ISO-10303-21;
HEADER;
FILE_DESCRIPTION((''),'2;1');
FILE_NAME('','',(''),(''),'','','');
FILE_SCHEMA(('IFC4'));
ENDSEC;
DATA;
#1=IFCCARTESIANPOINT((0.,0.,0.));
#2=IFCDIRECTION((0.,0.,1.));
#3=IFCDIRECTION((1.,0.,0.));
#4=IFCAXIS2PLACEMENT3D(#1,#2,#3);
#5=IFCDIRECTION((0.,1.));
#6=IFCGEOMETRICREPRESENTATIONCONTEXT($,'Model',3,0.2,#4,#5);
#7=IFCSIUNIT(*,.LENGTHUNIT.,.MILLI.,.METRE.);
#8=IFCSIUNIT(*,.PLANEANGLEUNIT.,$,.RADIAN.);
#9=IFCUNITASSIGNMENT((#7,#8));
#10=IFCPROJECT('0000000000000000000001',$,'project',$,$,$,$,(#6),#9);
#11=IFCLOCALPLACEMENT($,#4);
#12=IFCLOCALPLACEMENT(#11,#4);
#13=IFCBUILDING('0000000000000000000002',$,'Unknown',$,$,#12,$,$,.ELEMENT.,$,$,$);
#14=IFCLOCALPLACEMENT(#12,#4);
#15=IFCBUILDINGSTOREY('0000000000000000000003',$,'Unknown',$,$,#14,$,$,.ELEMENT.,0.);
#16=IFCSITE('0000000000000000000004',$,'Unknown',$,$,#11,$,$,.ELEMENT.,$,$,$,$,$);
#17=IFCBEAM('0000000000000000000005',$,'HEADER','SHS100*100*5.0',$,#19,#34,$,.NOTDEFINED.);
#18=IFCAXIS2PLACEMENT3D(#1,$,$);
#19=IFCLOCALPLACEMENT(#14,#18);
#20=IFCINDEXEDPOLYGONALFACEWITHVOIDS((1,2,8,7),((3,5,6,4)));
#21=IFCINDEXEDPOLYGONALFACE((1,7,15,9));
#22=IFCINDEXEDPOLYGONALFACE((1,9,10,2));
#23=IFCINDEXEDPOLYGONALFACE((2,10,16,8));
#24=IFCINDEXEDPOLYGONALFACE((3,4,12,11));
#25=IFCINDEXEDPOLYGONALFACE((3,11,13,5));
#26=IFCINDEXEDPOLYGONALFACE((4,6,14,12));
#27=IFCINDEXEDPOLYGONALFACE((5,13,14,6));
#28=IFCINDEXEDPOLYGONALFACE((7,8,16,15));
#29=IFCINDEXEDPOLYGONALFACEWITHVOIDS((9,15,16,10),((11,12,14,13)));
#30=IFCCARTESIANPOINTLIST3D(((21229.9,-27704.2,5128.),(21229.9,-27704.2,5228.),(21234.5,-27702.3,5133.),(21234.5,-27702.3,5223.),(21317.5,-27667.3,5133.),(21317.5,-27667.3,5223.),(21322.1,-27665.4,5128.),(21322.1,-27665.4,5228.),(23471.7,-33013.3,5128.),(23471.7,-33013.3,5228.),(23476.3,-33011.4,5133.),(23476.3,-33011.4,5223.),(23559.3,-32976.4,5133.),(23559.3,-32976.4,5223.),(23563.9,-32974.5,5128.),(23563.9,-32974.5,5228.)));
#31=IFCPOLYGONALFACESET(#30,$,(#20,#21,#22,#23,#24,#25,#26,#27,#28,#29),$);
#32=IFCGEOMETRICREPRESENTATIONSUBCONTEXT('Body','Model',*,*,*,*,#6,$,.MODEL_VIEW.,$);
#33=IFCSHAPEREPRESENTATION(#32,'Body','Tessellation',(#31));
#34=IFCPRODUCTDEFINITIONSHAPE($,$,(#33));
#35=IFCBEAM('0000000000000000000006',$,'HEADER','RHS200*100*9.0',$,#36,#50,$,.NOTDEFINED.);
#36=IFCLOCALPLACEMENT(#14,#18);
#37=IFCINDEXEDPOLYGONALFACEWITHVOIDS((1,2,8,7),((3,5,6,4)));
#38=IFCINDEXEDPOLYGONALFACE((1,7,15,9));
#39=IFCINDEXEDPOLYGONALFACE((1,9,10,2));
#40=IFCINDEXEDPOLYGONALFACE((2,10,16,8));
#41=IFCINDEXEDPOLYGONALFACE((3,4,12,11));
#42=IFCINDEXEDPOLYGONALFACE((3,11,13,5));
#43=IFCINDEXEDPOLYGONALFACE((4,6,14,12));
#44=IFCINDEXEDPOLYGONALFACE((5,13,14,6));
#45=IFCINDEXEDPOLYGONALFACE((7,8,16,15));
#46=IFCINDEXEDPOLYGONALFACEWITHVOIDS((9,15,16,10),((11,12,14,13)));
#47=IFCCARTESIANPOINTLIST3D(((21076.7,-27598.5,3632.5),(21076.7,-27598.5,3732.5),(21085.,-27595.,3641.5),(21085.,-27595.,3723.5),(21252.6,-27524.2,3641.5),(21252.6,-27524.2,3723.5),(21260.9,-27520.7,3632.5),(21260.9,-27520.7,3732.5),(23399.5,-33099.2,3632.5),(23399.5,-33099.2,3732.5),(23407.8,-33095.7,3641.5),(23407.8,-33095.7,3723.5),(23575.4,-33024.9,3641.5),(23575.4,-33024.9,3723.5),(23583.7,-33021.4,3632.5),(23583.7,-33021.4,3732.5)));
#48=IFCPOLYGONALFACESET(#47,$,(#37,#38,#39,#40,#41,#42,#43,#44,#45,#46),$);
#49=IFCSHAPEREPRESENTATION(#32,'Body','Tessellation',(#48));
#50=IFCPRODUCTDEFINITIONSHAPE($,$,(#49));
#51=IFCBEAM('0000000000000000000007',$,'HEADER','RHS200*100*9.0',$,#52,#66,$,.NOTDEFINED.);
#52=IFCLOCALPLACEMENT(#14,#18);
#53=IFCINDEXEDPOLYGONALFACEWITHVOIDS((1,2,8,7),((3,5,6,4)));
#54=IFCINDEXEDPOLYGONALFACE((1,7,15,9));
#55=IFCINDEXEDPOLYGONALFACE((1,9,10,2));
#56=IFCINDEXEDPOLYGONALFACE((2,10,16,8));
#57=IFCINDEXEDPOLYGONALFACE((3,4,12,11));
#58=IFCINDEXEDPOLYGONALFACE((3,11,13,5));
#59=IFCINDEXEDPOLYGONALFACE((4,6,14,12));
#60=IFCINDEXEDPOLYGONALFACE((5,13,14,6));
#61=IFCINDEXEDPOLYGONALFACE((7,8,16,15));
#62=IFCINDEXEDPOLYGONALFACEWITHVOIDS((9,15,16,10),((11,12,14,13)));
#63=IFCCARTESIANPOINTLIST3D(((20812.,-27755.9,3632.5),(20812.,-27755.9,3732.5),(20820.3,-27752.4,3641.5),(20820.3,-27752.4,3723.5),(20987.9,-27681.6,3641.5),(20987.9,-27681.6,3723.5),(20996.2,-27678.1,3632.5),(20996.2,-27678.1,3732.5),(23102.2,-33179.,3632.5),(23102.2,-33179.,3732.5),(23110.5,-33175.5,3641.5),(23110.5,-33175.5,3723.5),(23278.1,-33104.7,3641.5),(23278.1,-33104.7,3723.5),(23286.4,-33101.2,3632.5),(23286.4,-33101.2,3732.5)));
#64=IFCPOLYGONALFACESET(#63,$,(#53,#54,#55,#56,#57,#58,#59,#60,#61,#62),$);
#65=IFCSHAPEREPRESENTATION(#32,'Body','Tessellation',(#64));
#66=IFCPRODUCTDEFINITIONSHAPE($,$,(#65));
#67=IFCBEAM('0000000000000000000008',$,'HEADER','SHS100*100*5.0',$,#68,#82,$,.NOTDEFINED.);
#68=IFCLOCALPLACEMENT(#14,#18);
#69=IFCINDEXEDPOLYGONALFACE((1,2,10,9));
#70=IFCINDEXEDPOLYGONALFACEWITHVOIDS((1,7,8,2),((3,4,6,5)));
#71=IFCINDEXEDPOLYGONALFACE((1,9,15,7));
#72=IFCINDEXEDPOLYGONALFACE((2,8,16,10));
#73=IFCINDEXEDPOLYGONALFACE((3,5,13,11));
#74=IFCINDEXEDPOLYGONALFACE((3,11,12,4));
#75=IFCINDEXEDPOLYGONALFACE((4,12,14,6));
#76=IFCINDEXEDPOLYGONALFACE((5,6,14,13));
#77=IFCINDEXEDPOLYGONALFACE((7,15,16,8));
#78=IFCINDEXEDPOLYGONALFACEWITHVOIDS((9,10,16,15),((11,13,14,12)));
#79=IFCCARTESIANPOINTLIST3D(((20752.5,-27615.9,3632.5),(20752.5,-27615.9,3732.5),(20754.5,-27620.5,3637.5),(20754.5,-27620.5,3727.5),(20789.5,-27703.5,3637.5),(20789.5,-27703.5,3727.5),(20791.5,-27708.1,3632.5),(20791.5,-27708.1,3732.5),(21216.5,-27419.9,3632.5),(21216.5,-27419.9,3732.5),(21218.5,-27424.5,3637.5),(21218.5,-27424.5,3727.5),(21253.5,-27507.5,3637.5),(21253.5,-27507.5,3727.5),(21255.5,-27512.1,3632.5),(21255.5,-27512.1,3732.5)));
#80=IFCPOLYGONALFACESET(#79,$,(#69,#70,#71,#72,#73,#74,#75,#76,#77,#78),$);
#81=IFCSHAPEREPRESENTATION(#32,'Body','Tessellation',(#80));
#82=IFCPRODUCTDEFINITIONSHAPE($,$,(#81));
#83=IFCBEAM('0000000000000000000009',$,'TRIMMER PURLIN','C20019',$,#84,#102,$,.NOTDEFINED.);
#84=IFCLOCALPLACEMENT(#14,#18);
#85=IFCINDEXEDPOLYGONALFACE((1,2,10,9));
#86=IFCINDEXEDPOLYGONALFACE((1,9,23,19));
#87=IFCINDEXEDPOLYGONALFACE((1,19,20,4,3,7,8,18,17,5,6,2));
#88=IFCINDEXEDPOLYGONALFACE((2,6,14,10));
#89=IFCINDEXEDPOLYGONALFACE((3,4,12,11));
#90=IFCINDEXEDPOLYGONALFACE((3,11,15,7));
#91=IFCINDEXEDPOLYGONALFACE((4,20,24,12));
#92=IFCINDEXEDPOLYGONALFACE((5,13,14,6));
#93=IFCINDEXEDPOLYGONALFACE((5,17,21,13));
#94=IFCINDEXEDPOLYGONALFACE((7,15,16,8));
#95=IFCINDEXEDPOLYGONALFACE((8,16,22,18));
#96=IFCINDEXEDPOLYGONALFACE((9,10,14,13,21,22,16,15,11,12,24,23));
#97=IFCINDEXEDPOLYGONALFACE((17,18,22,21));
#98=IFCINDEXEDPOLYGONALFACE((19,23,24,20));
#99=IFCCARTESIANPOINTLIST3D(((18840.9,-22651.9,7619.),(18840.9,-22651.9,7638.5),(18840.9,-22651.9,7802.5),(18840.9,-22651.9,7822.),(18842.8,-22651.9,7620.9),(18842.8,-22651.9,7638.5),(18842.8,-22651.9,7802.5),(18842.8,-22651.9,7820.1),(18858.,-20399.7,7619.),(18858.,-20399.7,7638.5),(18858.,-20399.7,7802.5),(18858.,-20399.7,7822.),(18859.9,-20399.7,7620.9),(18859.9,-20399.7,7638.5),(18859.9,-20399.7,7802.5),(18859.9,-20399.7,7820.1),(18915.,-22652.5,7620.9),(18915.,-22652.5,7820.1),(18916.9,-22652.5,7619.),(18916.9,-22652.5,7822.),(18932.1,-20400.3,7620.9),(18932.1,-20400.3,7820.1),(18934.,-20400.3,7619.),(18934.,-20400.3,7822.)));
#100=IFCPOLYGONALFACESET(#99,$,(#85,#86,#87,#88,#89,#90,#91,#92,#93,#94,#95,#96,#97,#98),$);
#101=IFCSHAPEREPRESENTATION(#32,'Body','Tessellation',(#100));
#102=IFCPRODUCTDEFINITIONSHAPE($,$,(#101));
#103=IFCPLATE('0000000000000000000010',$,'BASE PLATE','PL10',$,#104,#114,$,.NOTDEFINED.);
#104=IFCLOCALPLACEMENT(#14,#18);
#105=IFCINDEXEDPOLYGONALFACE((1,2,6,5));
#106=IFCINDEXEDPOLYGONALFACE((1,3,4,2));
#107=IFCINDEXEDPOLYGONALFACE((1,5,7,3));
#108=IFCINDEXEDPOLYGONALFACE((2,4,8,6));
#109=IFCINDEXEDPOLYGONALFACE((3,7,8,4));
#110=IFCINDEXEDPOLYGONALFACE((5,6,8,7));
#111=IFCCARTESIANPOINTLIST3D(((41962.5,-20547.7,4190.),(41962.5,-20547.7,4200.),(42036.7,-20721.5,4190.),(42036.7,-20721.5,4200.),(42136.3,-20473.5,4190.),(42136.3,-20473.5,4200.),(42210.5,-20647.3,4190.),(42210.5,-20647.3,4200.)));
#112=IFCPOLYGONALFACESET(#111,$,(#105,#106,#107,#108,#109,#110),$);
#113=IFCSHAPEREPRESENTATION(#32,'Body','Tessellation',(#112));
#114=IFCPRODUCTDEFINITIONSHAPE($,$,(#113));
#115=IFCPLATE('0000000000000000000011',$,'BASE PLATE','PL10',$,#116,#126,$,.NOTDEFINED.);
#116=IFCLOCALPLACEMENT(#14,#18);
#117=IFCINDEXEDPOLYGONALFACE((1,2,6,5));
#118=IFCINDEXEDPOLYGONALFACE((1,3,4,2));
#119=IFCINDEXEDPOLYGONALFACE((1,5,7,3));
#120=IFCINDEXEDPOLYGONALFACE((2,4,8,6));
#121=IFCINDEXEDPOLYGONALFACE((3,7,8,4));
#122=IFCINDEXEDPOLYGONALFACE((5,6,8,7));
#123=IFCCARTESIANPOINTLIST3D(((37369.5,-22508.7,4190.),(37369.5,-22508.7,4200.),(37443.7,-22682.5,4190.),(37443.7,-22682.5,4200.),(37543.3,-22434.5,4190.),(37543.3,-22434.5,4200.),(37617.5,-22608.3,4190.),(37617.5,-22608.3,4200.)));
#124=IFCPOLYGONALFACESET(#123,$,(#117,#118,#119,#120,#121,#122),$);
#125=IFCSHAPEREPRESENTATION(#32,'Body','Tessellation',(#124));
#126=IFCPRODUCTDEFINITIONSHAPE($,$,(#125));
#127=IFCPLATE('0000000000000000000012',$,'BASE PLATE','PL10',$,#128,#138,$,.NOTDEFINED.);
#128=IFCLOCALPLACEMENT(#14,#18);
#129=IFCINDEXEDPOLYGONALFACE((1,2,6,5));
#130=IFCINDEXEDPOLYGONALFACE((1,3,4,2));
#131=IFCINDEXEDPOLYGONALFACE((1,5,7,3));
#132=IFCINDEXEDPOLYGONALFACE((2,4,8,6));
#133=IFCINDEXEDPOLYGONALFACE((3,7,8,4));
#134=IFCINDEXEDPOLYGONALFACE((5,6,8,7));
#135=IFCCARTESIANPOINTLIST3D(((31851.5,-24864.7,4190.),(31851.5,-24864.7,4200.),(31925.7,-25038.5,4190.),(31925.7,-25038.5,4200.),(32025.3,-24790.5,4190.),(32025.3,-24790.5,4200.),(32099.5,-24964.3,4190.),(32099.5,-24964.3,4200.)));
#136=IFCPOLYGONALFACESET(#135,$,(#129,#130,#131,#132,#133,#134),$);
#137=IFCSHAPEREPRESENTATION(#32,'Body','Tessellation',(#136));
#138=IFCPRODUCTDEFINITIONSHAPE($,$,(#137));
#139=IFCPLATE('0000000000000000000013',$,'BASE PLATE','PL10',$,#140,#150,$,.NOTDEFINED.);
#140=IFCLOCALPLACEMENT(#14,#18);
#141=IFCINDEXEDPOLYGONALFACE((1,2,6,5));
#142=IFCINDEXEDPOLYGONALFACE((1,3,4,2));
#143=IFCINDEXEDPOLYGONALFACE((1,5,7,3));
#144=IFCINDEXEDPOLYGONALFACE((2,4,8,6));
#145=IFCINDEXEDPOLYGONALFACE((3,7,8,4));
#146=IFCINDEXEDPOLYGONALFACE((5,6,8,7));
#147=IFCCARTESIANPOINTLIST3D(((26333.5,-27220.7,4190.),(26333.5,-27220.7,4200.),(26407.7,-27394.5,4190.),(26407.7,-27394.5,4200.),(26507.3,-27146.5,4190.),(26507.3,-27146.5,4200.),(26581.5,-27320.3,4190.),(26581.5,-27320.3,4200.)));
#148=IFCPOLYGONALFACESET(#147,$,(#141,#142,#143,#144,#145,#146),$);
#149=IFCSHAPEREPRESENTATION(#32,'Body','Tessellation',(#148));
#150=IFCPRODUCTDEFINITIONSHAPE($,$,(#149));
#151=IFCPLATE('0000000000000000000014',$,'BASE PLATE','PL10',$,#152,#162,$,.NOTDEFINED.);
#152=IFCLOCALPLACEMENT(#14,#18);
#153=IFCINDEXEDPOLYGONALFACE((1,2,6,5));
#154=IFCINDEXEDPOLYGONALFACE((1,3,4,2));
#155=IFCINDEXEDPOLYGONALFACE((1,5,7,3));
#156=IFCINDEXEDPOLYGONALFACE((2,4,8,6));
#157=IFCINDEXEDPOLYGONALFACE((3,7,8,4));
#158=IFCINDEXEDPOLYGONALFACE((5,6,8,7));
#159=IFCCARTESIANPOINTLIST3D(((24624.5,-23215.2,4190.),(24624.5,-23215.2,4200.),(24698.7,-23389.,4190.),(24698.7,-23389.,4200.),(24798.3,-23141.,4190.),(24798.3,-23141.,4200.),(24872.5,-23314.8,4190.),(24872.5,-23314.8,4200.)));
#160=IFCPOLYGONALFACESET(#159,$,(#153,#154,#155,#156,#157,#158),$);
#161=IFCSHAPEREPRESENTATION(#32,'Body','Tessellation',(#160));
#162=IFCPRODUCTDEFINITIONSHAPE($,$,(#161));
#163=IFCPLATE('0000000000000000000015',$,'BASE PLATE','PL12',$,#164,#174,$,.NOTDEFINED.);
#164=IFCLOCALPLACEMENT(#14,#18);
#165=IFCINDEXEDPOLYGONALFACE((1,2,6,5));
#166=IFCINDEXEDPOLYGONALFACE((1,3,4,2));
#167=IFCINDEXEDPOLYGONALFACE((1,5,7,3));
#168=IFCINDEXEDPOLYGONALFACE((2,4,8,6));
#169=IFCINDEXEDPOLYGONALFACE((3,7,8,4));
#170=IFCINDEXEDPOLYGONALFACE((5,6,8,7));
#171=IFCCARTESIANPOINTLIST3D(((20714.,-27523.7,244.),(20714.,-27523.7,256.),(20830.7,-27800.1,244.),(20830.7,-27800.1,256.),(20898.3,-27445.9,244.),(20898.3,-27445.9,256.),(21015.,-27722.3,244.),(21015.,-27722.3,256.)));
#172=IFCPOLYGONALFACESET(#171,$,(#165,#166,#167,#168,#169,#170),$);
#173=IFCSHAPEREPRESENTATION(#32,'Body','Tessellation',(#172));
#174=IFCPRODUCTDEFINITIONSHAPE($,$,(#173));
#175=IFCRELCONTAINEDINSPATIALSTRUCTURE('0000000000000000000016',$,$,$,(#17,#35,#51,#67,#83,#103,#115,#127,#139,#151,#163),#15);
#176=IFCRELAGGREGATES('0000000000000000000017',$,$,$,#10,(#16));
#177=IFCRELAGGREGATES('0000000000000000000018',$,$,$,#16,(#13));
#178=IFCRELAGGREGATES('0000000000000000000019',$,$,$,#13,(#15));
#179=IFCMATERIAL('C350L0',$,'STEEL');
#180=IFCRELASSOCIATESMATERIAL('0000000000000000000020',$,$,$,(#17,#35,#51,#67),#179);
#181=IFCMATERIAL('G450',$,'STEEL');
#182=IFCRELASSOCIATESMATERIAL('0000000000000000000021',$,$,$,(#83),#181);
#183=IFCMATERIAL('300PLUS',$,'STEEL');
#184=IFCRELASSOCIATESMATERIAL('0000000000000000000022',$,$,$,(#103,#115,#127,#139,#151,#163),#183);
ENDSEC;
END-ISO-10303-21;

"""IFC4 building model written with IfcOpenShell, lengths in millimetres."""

from ifc_helpers import new_model, si_unit, direction, frame, origin_with_axes, place, context, subcontext, project, spatial, line, indexed_curve, outline, extrude, material, element, save


model = new_model("IFC4")

# Units and contexts
model_context = context("Model", 3, precision=0.2, world=origin_with_axes(), true_north=direction((0.0, 1.0)))
body_context = subcontext(model_context, "Body", "Model", "MODEL_VIEW")
ifc_project = project(units=[si_unit("LENGTHUNIT", "METRE", prefix="MILLI"), si_unit("PLANEANGLEUNIT", "RADIAN")], contexts=[model_context])

# Site, building, storey
site_placement = place(None, origin_with_axes())
site = spatial("IfcSite", under=ifc_project, at=site_placement, Name="Unknown", CompositionType="ELEMENT")
building_placement = place(site_placement, origin_with_axes())
building = spatial("IfcBuilding", under=site, at=building_placement, Name="Unknown", CompositionType="ELEMENT")
storey_placement = place(building_placement, origin_with_axes())
storey = spatial("IfcBuildingStorey", under=building, at=storey_placement, Name="Unknown", CompositionType="ELEMENT", Elevation=0.0)

# Shared definitions
ifc_material_1 = material(Name="C350L0", Category="STEEL")

# Beams
beam_1_placement = place(storey_placement, frame((21276.0, -27684.8, 5178.0), z_axis=(0.0, 0.0, 1.0), x_axis=(0.388999, -0.921238, 0.0)))
element("IfcBeam", 1, at=beam_1_placement, inside=storey, material=ifc_material_1, Name="HEADER", Description="SHS100*100*5.0", PredefinedType="NOTDEFINED", context=body_context, shape_type="SolidModel", body=[
    extrude(outline(indexed_curve([(-50.0, -50.0), (50.0, -50.0), (50.0, 50.0), (-50.0, 50.0)], segments=[line(1, 2, 3, 4, 1)]), holes=[indexed_curve([(-45.0, -45.0), (-45.0, 45.0), (45.0, 45.0), (45.0, -45.0)], segments=[line(1, 2, 3, 4, 1)])]), frame((0.0, 0.0, 0.0), z_axis=(-1.0, 0.0, 0.0), x_axis=(0.0, 0.0, 1.0)), (0.0, 0.0, -1.0), 5763.0),
])
beam_2_placement = place(storey_placement, frame((21168.8, -27559.6, 3682.5), z_axis=(0.0, 0.0, 1.0), x_axis=(0.389012, -0.921233, 0.0)))
element("IfcBeam", 2, at=beam_2_placement, inside=storey, material=ifc_material_1, Name="HEADER", Description="RHS200*100*9.0", PredefinedType="NOTDEFINED", context=body_context, shape_type="SolidModel", body=[
    extrude(outline(indexed_curve([(-50.0, -100.0), (50.0, -100.0), (50.0, 100.0), (-50.0, 100.0)], segments=[line(1, 2, 3, 4, 1)]), holes=[indexed_curve([(-41.0, -91.0), (-41.0, 91.0), (41.0, 91.0), (41.0, -91.0)], segments=[line(1, 2, 3, 4, 1)])]), frame((0.0, 0.0, 0.0), z_axis=(-1.0, 0.0, 0.0), x_axis=(0.0, 0.0, 1.0)), (0.0, 0.0, -1.0), 5971.0),
])
beam_3_placement = place(storey_placement, frame((20904.1, -27717.0, 3682.5), z_axis=(0.0, 0.0, 1.0), x_axis=(0.389036, -0.921222, 0.0)))
element("IfcBeam", 3, at=beam_3_placement, inside=storey, material=ifc_material_1, Name="HEADER", Description="RHS200*100*9.0", PredefinedType="NOTDEFINED", context=body_context, shape_type="SolidModel", body=[
    extrude(outline(indexed_curve([(-50.0, -100.0), (50.0, -100.0), (50.0, 100.0), (-50.0, 100.0)], segments=[line(1, 2, 3, 4, 1)]), holes=[indexed_curve([(-41.0, -91.0), (-41.0, 91.0), (41.0, 91.0), (41.0, -91.0)], segments=[line(1, 2, 3, 4, 1)])]), frame((0.0, 0.0, 0.0), z_axis=(-1.0, 0.0, 0.0), x_axis=(0.0, 0.0, 1.0)), (0.0, 0.0, -1.0), 5886.9),
])
beam_4_placement = place(storey_placement, frame((20772.0, -27662.0, 3682.5), z_axis=(0.0, 0.0, 1.0), x_axis=(0.921186, 0.389122, 0.0)))
element("IfcBeam", 4, at=beam_4_placement, inside=storey, material=ifc_material_1, Name="HEADER", Description="SHS100*100*5.0", PredefinedType="NOTDEFINED", context=body_context, shape_type="SolidModel", body=[
    extrude(outline(indexed_curve([(-50.0, -50.0), (50.0, -50.0), (50.0, 50.0), (-50.0, 50.0)], segments=[line(1, 2, 3, 4, 1)]), holes=[indexed_curve([(-45.0, -45.0), (-45.0, 45.0), (45.0, 45.0), (45.0, -45.0)], segments=[line(1, 2, 3, 4, 1)])]), frame((0.0, 0.0, 0.0), z_axis=(-1.0, 0.0, 0.0), x_axis=(0.0, 0.0, 1.0)), (0.0, 0.0, -1.0), 503.7),
])
ifc_material_2 = material(Name="G450", Category="STEEL")
beam_5_placement = place(storey_placement, frame((18896.0, -20400.0, 7720.5), z_axis=(-0.999971, 0.007592, 0.0), x_axis=(-0.007592, -0.999971, 0.0)))
element("IfcBeam", 5, at=beam_5_placement, inside=storey, material=ifc_material_2, Name="TRIMMER PURLIN", Description="C20019", PredefinedType="NOTDEFINED", context=body_context, shape_type="SolidModel", body=[
    extrude(outline(indexed_curve([(38.0, -101.5), (38.0, -82.0), (36.1, -82.0), (36.1, -99.6), (-36.1, -99.6), (-36.1, 99.6), (36.1, 99.6), (36.1, 82.0), (38.0, 82.0), (38.0, 101.5), (-38.0, 101.5), (-38.0, -101.5)], segments=[line(1, 2, 3, 4, 5, 6, 7, 8, 9, 10, 11, 12, 1)])), frame((0.0, 0.0, 0.0), z_axis=(-1.0, 0.0, 0.0), x_axis=(0.0, 0.0, 1.0)), (0.0, 0.0, -1.0), 2252.3),
])

# Plates
ifc_material_3 = material(Name="300PLUS", Category="STEEL")
for number, where, z_axis, x_axis, name in (
    (6, (41962.5, -20547.7, 4195.0), (0.0, 0.0, 1.0), (0.392642, -0.919692, 0.0), "BASE PLATE"),
    (7, (37369.5, -22508.7, 4195.0), (0.0, 0.0, 1.0), (0.392642, -0.919692, 0.0), "BASE PLATE"),
    (8, (31851.5, -24864.7, 4195.0), (0.0, 0.0, 1.0), (0.392642, -0.919692, 0.0), "BASE PLATE"),
    (9, (26333.5, -27220.7, 4195.0), (0.0, 0.0, 1.0), (0.392642, -0.919692, 0.0), "BASE PLATE"),
    (10, (24624.5, -23215.2, 4195.0), (0.0, 0.0, 1.0), (0.392642, -0.919692, 0.0), "BASE PLATE"),
):
    element("IfcPlate", number, at=place(storey_placement, frame(where, z_axis=z_axis, x_axis=x_axis)), inside=storey, material=ifc_material_3, Name=name, Description="PL10", PredefinedType="NOTDEFINED", context=body_context, shape_type="SolidModel", body=[
        extrude(outline(indexed_curve([(0.0, 0.0), (189.0, 0.0), (189.0, 189.0), (0.0, 189.0)], segments=[line(1, 2, 3, 4, 1)])), frame((0.0, 0.0, 5.0), z_axis=(0.0, 0.0, 1.0), x_axis=(1.0, 0.0, 0.0)), (0.0, 0.0, -1.0), 10.0),
    ])
plate_placement = place(storey_placement, frame((21015.0, -27722.3, 250.0), z_axis=(0.0, 0.0, 1.0), x_axis=(-0.388966, 0.921252, 0.0)))
element("IfcPlate", 11, at=plate_placement, inside=storey, material=ifc_material_3, Name="BASE PLATE", Description="PL12", PredefinedType="NOTDEFINED", context=body_context, shape_type="SolidModel", body=[
    extrude(outline(indexed_curve([(0.0, 0.0), (300.0, 0.0), (300.0, 200.0), (0.0, 200.0)], segments=[line(1, 2, 3, 4, 1)])), frame((0.0, 0.0, 6.0), z_axis=(0.0, 0.0, 1.0), x_axis=(1.0, 0.0, 0.0)), (0.0, 0.0, -1.0), 12.0),
])

save(model, "model.ifc")
